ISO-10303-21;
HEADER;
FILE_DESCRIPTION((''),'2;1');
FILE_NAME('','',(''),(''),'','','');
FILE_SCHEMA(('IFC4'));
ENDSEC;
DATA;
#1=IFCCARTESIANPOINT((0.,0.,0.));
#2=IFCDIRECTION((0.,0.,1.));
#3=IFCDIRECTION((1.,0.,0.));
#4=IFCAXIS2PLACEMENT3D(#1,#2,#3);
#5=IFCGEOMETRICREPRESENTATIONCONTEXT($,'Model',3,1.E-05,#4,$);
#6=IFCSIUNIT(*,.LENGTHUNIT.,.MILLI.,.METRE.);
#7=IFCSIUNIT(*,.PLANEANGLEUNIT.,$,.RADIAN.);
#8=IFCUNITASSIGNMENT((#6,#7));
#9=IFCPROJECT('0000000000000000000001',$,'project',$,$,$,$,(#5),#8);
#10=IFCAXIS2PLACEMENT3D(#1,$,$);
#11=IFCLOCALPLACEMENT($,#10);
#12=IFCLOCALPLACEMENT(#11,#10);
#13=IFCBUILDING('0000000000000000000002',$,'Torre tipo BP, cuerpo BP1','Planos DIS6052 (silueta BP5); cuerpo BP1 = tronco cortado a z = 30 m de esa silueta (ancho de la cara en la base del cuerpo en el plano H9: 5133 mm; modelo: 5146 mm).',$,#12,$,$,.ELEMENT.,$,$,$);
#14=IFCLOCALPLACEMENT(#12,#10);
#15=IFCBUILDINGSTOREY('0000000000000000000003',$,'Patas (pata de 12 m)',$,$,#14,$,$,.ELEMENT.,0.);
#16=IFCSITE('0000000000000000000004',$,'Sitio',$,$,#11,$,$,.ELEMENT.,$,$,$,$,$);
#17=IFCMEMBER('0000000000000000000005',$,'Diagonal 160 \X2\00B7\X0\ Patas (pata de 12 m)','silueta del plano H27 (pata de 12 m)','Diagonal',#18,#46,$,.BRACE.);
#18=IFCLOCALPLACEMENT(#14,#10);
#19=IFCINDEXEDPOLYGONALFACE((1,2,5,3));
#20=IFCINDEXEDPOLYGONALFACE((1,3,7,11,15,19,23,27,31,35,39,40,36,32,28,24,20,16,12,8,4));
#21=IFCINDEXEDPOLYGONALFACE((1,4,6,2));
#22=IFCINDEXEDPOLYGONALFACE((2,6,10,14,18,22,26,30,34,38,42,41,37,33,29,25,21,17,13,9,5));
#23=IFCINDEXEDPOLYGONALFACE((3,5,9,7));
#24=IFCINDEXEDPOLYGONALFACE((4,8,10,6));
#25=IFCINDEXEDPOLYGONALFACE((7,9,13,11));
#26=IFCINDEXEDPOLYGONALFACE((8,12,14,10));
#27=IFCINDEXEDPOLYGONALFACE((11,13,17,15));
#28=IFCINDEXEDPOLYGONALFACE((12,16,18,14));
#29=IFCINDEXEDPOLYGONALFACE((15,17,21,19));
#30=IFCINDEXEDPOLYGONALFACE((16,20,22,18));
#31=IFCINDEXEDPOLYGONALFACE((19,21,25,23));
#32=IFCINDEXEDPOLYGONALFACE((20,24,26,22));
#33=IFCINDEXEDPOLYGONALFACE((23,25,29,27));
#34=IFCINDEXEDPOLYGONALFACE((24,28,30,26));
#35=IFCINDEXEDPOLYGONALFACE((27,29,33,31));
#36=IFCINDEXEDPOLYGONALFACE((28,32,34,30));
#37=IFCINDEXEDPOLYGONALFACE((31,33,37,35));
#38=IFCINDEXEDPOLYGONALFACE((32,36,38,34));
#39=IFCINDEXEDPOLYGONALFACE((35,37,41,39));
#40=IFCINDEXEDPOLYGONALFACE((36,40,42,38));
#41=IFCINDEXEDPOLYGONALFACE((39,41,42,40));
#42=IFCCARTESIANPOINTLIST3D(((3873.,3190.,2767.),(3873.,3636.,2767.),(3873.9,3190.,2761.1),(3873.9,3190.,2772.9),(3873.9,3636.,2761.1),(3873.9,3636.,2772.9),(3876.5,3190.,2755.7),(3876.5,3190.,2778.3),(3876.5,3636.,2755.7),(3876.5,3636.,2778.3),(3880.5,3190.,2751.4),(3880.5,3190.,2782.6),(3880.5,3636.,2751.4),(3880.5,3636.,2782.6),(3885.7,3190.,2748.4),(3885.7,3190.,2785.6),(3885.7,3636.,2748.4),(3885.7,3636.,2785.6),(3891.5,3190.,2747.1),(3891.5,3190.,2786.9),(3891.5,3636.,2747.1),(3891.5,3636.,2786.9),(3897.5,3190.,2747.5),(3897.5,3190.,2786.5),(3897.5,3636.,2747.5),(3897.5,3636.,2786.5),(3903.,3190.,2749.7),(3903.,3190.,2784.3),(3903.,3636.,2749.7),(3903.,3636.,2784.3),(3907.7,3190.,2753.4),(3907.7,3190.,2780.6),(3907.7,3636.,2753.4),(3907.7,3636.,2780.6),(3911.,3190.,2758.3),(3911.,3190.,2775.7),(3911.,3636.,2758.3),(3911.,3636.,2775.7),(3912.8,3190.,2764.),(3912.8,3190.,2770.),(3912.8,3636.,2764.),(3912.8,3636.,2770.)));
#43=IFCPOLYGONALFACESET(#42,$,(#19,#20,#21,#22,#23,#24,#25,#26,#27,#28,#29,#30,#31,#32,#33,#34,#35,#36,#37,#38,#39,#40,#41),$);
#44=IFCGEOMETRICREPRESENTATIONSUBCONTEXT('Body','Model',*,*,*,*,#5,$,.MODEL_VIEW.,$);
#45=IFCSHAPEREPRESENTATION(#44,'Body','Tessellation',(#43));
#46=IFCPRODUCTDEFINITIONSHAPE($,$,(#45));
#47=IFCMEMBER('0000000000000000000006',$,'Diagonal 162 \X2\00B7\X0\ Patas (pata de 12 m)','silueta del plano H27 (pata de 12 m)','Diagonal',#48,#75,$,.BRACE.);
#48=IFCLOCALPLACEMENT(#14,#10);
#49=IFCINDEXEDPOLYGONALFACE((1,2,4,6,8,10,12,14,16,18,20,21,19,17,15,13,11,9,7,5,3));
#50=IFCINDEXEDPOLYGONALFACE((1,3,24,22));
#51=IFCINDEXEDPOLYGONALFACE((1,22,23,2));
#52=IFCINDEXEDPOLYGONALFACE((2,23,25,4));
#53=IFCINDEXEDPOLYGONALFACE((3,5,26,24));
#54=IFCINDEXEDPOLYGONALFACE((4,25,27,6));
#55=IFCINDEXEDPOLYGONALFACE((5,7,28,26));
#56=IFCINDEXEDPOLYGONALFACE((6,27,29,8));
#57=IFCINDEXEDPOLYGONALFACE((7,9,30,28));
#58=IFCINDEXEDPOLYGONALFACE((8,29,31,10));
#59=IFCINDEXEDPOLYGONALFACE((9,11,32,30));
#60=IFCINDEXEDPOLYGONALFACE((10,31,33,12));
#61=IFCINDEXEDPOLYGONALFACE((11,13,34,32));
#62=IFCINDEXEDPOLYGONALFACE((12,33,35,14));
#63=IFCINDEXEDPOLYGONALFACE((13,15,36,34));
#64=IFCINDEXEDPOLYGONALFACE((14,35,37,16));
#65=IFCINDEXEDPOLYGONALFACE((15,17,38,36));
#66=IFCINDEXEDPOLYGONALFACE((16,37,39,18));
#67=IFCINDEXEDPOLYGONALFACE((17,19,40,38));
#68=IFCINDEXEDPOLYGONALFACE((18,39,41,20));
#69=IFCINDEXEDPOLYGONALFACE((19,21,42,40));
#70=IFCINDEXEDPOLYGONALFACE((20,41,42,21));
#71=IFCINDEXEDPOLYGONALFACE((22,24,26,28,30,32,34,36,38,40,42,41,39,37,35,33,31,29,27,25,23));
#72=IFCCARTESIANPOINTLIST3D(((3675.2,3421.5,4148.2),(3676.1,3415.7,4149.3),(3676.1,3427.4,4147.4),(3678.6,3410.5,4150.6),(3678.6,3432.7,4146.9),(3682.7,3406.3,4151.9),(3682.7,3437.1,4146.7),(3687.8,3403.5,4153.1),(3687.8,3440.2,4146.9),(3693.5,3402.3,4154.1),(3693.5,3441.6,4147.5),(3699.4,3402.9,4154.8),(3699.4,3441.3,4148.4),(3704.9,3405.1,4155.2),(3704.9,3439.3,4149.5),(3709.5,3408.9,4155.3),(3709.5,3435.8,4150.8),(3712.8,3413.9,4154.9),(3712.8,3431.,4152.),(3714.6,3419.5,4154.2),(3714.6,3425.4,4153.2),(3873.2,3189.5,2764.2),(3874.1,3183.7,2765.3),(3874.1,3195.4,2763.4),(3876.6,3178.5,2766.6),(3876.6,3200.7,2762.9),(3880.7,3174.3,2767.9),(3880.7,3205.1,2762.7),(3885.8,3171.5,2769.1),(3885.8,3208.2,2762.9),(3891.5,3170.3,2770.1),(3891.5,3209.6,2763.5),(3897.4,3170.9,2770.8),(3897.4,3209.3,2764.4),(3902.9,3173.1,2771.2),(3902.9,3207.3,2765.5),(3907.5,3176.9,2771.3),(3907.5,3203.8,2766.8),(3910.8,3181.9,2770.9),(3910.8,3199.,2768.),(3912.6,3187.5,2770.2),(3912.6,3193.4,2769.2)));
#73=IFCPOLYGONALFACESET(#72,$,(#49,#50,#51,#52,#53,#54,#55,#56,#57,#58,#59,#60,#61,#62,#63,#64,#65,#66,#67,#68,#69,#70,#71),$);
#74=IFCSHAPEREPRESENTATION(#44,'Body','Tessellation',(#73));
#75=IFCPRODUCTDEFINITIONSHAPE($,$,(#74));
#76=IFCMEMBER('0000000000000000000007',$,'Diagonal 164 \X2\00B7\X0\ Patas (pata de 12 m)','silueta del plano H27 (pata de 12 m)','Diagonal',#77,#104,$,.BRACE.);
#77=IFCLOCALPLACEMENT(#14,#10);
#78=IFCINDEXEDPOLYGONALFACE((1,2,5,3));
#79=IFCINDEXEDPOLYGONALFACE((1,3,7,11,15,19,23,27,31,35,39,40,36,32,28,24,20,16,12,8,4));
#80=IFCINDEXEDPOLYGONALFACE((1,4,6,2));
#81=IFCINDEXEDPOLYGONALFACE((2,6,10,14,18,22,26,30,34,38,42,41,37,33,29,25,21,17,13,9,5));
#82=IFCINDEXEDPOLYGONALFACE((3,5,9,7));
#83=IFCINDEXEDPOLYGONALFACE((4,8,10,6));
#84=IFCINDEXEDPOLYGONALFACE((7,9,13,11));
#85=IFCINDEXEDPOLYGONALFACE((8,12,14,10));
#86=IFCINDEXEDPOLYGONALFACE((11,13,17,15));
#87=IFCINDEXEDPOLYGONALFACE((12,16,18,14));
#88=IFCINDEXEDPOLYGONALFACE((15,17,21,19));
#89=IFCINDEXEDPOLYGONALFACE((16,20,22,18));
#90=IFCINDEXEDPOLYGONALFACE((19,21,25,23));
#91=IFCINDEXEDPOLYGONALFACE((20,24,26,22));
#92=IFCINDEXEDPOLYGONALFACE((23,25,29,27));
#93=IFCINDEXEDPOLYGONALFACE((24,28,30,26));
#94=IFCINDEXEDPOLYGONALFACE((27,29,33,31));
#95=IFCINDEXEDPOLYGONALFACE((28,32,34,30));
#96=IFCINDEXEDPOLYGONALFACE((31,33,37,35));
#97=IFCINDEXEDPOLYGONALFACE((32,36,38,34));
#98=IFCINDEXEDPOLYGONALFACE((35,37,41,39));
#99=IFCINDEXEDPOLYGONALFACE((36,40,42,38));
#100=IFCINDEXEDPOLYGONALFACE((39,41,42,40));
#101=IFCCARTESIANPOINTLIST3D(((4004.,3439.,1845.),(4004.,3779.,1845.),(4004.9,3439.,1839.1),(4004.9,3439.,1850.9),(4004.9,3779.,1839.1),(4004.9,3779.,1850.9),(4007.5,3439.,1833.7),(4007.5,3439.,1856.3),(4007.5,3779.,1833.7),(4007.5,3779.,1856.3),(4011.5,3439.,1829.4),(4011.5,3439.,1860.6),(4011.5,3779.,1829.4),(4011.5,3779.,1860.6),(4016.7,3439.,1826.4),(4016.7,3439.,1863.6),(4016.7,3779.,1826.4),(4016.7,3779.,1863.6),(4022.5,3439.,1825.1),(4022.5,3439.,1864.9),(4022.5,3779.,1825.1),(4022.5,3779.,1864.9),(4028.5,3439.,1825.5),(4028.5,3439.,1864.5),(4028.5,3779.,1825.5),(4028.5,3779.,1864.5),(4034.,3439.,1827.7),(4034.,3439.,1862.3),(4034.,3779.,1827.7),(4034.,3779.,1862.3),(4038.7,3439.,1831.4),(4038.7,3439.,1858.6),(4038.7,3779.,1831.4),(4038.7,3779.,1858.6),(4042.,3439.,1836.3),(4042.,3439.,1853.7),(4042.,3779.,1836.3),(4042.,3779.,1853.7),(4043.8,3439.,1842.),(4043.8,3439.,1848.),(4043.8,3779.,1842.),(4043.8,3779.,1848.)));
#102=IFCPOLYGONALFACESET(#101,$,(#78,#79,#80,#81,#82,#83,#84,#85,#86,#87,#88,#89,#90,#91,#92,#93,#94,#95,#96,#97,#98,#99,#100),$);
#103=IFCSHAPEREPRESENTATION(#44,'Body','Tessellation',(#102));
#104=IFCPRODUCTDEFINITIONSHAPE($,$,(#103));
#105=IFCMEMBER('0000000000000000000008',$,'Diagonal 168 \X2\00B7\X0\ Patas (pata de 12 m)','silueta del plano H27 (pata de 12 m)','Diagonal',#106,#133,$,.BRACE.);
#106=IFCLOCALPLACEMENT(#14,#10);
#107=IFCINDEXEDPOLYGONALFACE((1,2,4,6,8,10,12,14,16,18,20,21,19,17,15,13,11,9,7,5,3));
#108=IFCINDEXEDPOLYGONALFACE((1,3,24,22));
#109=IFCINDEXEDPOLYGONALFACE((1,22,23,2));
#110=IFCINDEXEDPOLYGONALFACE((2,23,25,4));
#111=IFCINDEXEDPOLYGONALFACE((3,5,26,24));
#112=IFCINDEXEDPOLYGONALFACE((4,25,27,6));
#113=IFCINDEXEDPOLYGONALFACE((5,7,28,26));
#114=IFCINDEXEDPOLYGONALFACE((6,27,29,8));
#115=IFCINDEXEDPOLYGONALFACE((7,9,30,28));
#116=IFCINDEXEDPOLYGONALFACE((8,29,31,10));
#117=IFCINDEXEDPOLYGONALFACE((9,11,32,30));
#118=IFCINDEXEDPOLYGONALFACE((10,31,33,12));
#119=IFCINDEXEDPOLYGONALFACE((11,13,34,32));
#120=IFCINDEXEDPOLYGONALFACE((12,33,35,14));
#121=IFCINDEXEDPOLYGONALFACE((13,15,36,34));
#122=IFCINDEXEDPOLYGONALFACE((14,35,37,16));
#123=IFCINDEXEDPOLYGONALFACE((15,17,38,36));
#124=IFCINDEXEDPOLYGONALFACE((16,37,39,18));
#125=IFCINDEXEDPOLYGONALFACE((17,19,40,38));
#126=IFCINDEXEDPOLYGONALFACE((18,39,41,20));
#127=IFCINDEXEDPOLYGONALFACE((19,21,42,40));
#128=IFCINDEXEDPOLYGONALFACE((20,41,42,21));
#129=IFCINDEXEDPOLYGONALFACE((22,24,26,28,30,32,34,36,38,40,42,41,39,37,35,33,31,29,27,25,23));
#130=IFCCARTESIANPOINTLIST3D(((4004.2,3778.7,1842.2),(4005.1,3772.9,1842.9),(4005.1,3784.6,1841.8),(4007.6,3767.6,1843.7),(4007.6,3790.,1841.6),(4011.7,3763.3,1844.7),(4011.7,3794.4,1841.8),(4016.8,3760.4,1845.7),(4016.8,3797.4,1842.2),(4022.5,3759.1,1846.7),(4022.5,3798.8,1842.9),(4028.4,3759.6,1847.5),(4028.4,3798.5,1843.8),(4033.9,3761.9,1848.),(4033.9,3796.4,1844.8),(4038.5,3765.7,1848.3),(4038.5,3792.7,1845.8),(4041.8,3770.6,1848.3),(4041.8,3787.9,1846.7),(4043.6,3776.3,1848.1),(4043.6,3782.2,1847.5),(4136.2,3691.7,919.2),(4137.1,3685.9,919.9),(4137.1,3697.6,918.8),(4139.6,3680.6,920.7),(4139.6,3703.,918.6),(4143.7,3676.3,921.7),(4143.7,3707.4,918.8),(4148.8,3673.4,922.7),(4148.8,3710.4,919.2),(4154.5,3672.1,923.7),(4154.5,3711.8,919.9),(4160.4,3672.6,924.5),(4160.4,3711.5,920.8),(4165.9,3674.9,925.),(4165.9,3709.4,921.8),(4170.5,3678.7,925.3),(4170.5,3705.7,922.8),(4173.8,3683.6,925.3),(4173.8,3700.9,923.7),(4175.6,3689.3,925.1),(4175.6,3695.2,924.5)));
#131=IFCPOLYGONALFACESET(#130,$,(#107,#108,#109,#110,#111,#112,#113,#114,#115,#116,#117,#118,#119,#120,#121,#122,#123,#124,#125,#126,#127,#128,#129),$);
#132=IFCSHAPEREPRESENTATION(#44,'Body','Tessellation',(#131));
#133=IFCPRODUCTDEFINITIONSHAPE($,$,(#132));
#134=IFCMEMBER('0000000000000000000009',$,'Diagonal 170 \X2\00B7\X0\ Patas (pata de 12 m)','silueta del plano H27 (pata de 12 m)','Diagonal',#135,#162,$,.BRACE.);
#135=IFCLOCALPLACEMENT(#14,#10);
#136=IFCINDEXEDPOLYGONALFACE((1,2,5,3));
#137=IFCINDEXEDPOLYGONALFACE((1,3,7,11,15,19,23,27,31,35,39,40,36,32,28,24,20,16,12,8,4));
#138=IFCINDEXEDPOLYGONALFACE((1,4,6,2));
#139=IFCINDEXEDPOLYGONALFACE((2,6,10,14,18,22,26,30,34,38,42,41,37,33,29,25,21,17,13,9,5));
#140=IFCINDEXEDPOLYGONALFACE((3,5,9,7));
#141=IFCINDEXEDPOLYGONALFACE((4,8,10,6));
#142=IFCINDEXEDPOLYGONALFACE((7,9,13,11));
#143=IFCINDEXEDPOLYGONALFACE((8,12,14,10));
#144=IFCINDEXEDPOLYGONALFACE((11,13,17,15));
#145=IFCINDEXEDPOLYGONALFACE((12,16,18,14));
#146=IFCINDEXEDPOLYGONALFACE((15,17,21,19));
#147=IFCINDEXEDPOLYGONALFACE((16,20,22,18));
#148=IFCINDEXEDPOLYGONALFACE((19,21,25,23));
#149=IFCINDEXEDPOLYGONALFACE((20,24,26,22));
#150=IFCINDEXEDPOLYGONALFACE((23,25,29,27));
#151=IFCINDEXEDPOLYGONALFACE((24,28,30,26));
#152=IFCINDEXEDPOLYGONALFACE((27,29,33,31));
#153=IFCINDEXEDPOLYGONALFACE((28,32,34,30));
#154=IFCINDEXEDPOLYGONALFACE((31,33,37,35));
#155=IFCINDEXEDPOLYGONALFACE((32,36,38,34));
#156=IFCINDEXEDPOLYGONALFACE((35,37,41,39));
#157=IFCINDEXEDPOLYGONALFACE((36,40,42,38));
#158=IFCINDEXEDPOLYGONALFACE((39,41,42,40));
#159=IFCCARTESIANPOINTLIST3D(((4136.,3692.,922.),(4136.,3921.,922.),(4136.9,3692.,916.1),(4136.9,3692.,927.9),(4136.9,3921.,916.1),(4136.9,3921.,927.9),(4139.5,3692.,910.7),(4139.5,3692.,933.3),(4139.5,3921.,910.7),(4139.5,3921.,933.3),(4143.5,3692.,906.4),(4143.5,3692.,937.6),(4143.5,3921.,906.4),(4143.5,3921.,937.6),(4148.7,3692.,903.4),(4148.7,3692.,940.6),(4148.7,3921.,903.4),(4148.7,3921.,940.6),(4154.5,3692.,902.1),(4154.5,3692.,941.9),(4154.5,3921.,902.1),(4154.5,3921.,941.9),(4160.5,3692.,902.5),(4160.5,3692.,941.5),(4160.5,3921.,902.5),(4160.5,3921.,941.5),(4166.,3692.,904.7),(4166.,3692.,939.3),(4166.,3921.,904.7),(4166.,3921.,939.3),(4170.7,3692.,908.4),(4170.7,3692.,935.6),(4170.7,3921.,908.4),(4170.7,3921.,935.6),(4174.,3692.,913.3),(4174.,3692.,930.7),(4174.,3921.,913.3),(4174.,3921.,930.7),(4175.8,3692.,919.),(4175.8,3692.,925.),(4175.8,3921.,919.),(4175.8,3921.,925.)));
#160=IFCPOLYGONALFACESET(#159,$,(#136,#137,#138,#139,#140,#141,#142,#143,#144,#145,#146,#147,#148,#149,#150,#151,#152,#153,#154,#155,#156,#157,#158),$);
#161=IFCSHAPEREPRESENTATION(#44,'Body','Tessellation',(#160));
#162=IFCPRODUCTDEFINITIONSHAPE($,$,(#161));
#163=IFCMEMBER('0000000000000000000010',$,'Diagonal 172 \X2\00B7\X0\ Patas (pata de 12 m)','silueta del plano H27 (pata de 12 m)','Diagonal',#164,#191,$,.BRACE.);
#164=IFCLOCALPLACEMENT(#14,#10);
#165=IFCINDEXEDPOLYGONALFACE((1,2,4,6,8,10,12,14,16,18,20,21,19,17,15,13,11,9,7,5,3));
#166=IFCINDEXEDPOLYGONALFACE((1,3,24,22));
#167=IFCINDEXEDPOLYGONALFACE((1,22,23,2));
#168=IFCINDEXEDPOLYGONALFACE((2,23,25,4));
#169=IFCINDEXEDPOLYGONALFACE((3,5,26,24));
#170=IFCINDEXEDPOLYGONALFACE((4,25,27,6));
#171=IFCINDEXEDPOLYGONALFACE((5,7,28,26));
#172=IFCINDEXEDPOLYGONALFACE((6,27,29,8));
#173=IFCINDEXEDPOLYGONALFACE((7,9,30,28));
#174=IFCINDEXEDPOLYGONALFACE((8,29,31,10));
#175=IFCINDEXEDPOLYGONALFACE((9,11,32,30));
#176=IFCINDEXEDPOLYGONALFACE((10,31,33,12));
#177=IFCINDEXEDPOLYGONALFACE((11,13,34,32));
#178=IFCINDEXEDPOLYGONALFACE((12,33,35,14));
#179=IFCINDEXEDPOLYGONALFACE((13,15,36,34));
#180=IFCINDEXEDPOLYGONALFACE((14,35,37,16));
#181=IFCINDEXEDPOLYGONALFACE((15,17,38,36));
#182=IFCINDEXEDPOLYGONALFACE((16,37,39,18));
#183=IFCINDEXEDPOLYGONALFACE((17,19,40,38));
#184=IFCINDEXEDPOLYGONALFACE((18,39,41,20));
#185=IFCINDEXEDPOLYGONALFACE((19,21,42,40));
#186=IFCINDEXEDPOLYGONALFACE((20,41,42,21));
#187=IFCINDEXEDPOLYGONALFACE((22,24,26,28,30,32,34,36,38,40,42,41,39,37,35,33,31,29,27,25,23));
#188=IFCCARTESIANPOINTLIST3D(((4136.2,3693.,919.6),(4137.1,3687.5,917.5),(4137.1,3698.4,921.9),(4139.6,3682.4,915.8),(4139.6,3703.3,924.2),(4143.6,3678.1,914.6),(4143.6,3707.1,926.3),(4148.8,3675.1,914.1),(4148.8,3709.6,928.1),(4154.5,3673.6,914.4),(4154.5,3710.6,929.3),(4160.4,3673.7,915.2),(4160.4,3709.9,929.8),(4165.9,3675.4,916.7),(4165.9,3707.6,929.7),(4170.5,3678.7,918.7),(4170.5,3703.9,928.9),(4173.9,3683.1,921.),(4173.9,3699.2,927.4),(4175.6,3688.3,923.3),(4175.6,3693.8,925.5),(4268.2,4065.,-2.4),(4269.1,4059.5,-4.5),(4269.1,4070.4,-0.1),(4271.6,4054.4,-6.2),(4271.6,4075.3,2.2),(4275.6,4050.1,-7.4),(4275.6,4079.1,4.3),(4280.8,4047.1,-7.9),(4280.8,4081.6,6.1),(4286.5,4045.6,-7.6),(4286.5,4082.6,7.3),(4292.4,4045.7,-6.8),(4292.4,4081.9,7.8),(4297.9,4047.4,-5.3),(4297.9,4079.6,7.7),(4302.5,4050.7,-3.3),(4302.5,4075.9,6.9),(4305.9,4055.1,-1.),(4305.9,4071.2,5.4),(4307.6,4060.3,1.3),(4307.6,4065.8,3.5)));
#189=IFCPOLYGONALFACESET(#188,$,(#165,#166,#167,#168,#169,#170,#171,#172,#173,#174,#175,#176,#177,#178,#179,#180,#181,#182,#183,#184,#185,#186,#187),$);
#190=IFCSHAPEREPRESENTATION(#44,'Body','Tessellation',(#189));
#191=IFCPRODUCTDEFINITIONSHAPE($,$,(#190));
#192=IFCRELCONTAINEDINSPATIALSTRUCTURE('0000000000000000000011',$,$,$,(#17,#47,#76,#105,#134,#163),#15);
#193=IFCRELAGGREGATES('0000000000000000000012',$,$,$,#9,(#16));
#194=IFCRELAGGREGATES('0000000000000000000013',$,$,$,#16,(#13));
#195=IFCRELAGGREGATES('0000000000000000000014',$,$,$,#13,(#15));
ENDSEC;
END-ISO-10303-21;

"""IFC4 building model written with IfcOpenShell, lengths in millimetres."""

from ifc_helpers import new_model, si_unit, frame, origin, origin_with_axes, place, context, subcontext, project, spatial, circle, extrude, element, save


model = new_model("IFC4")

# Units and contexts
model_context = context("Model", 3, precision=1e-05, world=origin_with_axes())
body_context = subcontext(model_context, "Body", "Model", "MODEL_VIEW")
ifc_project = project(units=[si_unit("LENGTHUNIT", "METRE", prefix="MILLI"), si_unit("PLANEANGLEUNIT", "RADIAN")], contexts=[model_context])

# Site, building, storey
site_placement = place(None, origin())
site = spatial("IfcSite", under=ifc_project, at=site_placement, Name="Sitio", CompositionType="ELEMENT")
building_placement = place(site_placement, origin())
building = spatial("IfcBuilding", under=site, at=building_placement, Name="Torre tipo BP, cuerpo BP1", Description="Planos DIS6052 (silueta BP5); cuerpo BP1 = tronco cortado a z = 30 m de esa silueta (ancho de la cara en la base del cuerpo en el plano H9: 5133 mm; modelo: 5146 mm).", CompositionType="ELEMENT")
storey_placement = place(building_placement, origin())
storey = spatial("IfcBuildingStorey", under=building, at=storey_placement, Name="Patas (pata de 12 m)", CompositionType="ELEMENT", Elevation=0.0)

# Members
member_1_placement = place(storey_placement, frame((3893.0, 3636.0, 2767.0), z_axis=(0.0, -1.0, 0.0), x_axis=(-1.0, 0.0, 0.0)))
element("IfcMember", 1, at=member_1_placement, inside=storey, Name="Diagonal 160 · Patas (pata de 12 m)", Description="silueta del plano H27 (pata de 12 m)", ObjectType="Diagonal", PredefinedType="BRACE", context=body_context, shape_type="SweptSolid", body=[
    extrude(circle(Radius=20.0), None, (0.0, 0.0, 1.0), 446.0),
])
member_2_placement = place(storey_placement, frame((3893.0, 3190.0, 2767.0), z_axis=(-0.139711, 0.163702, 0.976567), x_axis=(-0.990192, -0.023098, -0.137789)))
element("IfcMember", 2, at=member_2_placement, inside=storey, Name="Diagonal 162 · Patas (pata de 12 m)", Description="silueta del plano H27 (pata de 12 m)", ObjectType="Diagonal", PredefinedType="BRACE", context=body_context, shape_type="SweptSolid", body=[
    extrude(circle(Radius=20.0), None, (0.0, 0.0, 1.0), 1417.2),
])
member_3_placement = place(storey_placement, frame((4024.0, 3779.0, 1845.0), z_axis=(0.0, -1.0, 0.0), x_axis=(-1.0, 0.0, 0.0)))
element("IfcMember", 3, at=member_3_placement, inside=storey, Name="Diagonal 164 · Patas (pata de 12 m)", Description="silueta del plano H27 (pata de 12 m)", ObjectType="Diagonal", PredefinedType="BRACE", context=body_context, shape_type="SweptSolid", body=[
    extrude(circle(Radius=20.0), None, (0.0, 0.0, 1.0), 340.0),
])
member_4_placement = place(storey_placement, frame((4156.0, 3692.0, 922.0), z_axis=(-0.140959, 0.092905, 0.985647), x_axis=(-0.990015, -0.013228, -0.140337)))
element("IfcMember", 4, at=member_4_placement, inside=storey, Name="Diagonal 168 · Patas (pata de 12 m)", Description="silueta del plano H27 (pata de 12 m)", ObjectType="Diagonal", PredefinedType="BRACE", context=body_context, shape_type="SweptSolid", body=[
    extrude(circle(Radius=20.0), None, (0.0, 0.0, 1.0), 936.4),
])
member_5_placement = place(storey_placement, frame((4156.0, 3921.0, 922.0), z_axis=(0.0, -1.0, 0.0), x_axis=(-1.0, 0.0, 0.0)))
element("IfcMember", 5, at=member_5_placement, inside=storey, Name="Diagonal 170 · Patas (pata de 12 m)", Description="silueta del plano H27 (pata de 12 m)", ObjectType="Diagonal", PredefinedType="BRACE", context=body_context, shape_type="SweptSolid", body=[
    extrude(circle(Radius=20.0), None, (0.0, 0.0, 1.0), 229.0),
])
member_6_placement = place(storey_placement, frame((4288.0, 4064.0, 0.0), z_axis=(-0.131613, -0.370909, 0.919296), x_axis=(-0.991301, 0.049245, -0.122053)))
element("IfcMember", 6, at=member_6_placement, inside=storey, Name="Diagonal 172 · Patas (pata de 12 m)", Description="silueta del plano H27 (pata de 12 m)", ObjectType="Diagonal", PredefinedType="BRACE", context=body_context, shape_type="SweptSolid", body=[
    extrude(circle(Radius=20.0), None, (0.0, 0.0, 1.0), 1002.9),
])

save(model, "model.ifc")
